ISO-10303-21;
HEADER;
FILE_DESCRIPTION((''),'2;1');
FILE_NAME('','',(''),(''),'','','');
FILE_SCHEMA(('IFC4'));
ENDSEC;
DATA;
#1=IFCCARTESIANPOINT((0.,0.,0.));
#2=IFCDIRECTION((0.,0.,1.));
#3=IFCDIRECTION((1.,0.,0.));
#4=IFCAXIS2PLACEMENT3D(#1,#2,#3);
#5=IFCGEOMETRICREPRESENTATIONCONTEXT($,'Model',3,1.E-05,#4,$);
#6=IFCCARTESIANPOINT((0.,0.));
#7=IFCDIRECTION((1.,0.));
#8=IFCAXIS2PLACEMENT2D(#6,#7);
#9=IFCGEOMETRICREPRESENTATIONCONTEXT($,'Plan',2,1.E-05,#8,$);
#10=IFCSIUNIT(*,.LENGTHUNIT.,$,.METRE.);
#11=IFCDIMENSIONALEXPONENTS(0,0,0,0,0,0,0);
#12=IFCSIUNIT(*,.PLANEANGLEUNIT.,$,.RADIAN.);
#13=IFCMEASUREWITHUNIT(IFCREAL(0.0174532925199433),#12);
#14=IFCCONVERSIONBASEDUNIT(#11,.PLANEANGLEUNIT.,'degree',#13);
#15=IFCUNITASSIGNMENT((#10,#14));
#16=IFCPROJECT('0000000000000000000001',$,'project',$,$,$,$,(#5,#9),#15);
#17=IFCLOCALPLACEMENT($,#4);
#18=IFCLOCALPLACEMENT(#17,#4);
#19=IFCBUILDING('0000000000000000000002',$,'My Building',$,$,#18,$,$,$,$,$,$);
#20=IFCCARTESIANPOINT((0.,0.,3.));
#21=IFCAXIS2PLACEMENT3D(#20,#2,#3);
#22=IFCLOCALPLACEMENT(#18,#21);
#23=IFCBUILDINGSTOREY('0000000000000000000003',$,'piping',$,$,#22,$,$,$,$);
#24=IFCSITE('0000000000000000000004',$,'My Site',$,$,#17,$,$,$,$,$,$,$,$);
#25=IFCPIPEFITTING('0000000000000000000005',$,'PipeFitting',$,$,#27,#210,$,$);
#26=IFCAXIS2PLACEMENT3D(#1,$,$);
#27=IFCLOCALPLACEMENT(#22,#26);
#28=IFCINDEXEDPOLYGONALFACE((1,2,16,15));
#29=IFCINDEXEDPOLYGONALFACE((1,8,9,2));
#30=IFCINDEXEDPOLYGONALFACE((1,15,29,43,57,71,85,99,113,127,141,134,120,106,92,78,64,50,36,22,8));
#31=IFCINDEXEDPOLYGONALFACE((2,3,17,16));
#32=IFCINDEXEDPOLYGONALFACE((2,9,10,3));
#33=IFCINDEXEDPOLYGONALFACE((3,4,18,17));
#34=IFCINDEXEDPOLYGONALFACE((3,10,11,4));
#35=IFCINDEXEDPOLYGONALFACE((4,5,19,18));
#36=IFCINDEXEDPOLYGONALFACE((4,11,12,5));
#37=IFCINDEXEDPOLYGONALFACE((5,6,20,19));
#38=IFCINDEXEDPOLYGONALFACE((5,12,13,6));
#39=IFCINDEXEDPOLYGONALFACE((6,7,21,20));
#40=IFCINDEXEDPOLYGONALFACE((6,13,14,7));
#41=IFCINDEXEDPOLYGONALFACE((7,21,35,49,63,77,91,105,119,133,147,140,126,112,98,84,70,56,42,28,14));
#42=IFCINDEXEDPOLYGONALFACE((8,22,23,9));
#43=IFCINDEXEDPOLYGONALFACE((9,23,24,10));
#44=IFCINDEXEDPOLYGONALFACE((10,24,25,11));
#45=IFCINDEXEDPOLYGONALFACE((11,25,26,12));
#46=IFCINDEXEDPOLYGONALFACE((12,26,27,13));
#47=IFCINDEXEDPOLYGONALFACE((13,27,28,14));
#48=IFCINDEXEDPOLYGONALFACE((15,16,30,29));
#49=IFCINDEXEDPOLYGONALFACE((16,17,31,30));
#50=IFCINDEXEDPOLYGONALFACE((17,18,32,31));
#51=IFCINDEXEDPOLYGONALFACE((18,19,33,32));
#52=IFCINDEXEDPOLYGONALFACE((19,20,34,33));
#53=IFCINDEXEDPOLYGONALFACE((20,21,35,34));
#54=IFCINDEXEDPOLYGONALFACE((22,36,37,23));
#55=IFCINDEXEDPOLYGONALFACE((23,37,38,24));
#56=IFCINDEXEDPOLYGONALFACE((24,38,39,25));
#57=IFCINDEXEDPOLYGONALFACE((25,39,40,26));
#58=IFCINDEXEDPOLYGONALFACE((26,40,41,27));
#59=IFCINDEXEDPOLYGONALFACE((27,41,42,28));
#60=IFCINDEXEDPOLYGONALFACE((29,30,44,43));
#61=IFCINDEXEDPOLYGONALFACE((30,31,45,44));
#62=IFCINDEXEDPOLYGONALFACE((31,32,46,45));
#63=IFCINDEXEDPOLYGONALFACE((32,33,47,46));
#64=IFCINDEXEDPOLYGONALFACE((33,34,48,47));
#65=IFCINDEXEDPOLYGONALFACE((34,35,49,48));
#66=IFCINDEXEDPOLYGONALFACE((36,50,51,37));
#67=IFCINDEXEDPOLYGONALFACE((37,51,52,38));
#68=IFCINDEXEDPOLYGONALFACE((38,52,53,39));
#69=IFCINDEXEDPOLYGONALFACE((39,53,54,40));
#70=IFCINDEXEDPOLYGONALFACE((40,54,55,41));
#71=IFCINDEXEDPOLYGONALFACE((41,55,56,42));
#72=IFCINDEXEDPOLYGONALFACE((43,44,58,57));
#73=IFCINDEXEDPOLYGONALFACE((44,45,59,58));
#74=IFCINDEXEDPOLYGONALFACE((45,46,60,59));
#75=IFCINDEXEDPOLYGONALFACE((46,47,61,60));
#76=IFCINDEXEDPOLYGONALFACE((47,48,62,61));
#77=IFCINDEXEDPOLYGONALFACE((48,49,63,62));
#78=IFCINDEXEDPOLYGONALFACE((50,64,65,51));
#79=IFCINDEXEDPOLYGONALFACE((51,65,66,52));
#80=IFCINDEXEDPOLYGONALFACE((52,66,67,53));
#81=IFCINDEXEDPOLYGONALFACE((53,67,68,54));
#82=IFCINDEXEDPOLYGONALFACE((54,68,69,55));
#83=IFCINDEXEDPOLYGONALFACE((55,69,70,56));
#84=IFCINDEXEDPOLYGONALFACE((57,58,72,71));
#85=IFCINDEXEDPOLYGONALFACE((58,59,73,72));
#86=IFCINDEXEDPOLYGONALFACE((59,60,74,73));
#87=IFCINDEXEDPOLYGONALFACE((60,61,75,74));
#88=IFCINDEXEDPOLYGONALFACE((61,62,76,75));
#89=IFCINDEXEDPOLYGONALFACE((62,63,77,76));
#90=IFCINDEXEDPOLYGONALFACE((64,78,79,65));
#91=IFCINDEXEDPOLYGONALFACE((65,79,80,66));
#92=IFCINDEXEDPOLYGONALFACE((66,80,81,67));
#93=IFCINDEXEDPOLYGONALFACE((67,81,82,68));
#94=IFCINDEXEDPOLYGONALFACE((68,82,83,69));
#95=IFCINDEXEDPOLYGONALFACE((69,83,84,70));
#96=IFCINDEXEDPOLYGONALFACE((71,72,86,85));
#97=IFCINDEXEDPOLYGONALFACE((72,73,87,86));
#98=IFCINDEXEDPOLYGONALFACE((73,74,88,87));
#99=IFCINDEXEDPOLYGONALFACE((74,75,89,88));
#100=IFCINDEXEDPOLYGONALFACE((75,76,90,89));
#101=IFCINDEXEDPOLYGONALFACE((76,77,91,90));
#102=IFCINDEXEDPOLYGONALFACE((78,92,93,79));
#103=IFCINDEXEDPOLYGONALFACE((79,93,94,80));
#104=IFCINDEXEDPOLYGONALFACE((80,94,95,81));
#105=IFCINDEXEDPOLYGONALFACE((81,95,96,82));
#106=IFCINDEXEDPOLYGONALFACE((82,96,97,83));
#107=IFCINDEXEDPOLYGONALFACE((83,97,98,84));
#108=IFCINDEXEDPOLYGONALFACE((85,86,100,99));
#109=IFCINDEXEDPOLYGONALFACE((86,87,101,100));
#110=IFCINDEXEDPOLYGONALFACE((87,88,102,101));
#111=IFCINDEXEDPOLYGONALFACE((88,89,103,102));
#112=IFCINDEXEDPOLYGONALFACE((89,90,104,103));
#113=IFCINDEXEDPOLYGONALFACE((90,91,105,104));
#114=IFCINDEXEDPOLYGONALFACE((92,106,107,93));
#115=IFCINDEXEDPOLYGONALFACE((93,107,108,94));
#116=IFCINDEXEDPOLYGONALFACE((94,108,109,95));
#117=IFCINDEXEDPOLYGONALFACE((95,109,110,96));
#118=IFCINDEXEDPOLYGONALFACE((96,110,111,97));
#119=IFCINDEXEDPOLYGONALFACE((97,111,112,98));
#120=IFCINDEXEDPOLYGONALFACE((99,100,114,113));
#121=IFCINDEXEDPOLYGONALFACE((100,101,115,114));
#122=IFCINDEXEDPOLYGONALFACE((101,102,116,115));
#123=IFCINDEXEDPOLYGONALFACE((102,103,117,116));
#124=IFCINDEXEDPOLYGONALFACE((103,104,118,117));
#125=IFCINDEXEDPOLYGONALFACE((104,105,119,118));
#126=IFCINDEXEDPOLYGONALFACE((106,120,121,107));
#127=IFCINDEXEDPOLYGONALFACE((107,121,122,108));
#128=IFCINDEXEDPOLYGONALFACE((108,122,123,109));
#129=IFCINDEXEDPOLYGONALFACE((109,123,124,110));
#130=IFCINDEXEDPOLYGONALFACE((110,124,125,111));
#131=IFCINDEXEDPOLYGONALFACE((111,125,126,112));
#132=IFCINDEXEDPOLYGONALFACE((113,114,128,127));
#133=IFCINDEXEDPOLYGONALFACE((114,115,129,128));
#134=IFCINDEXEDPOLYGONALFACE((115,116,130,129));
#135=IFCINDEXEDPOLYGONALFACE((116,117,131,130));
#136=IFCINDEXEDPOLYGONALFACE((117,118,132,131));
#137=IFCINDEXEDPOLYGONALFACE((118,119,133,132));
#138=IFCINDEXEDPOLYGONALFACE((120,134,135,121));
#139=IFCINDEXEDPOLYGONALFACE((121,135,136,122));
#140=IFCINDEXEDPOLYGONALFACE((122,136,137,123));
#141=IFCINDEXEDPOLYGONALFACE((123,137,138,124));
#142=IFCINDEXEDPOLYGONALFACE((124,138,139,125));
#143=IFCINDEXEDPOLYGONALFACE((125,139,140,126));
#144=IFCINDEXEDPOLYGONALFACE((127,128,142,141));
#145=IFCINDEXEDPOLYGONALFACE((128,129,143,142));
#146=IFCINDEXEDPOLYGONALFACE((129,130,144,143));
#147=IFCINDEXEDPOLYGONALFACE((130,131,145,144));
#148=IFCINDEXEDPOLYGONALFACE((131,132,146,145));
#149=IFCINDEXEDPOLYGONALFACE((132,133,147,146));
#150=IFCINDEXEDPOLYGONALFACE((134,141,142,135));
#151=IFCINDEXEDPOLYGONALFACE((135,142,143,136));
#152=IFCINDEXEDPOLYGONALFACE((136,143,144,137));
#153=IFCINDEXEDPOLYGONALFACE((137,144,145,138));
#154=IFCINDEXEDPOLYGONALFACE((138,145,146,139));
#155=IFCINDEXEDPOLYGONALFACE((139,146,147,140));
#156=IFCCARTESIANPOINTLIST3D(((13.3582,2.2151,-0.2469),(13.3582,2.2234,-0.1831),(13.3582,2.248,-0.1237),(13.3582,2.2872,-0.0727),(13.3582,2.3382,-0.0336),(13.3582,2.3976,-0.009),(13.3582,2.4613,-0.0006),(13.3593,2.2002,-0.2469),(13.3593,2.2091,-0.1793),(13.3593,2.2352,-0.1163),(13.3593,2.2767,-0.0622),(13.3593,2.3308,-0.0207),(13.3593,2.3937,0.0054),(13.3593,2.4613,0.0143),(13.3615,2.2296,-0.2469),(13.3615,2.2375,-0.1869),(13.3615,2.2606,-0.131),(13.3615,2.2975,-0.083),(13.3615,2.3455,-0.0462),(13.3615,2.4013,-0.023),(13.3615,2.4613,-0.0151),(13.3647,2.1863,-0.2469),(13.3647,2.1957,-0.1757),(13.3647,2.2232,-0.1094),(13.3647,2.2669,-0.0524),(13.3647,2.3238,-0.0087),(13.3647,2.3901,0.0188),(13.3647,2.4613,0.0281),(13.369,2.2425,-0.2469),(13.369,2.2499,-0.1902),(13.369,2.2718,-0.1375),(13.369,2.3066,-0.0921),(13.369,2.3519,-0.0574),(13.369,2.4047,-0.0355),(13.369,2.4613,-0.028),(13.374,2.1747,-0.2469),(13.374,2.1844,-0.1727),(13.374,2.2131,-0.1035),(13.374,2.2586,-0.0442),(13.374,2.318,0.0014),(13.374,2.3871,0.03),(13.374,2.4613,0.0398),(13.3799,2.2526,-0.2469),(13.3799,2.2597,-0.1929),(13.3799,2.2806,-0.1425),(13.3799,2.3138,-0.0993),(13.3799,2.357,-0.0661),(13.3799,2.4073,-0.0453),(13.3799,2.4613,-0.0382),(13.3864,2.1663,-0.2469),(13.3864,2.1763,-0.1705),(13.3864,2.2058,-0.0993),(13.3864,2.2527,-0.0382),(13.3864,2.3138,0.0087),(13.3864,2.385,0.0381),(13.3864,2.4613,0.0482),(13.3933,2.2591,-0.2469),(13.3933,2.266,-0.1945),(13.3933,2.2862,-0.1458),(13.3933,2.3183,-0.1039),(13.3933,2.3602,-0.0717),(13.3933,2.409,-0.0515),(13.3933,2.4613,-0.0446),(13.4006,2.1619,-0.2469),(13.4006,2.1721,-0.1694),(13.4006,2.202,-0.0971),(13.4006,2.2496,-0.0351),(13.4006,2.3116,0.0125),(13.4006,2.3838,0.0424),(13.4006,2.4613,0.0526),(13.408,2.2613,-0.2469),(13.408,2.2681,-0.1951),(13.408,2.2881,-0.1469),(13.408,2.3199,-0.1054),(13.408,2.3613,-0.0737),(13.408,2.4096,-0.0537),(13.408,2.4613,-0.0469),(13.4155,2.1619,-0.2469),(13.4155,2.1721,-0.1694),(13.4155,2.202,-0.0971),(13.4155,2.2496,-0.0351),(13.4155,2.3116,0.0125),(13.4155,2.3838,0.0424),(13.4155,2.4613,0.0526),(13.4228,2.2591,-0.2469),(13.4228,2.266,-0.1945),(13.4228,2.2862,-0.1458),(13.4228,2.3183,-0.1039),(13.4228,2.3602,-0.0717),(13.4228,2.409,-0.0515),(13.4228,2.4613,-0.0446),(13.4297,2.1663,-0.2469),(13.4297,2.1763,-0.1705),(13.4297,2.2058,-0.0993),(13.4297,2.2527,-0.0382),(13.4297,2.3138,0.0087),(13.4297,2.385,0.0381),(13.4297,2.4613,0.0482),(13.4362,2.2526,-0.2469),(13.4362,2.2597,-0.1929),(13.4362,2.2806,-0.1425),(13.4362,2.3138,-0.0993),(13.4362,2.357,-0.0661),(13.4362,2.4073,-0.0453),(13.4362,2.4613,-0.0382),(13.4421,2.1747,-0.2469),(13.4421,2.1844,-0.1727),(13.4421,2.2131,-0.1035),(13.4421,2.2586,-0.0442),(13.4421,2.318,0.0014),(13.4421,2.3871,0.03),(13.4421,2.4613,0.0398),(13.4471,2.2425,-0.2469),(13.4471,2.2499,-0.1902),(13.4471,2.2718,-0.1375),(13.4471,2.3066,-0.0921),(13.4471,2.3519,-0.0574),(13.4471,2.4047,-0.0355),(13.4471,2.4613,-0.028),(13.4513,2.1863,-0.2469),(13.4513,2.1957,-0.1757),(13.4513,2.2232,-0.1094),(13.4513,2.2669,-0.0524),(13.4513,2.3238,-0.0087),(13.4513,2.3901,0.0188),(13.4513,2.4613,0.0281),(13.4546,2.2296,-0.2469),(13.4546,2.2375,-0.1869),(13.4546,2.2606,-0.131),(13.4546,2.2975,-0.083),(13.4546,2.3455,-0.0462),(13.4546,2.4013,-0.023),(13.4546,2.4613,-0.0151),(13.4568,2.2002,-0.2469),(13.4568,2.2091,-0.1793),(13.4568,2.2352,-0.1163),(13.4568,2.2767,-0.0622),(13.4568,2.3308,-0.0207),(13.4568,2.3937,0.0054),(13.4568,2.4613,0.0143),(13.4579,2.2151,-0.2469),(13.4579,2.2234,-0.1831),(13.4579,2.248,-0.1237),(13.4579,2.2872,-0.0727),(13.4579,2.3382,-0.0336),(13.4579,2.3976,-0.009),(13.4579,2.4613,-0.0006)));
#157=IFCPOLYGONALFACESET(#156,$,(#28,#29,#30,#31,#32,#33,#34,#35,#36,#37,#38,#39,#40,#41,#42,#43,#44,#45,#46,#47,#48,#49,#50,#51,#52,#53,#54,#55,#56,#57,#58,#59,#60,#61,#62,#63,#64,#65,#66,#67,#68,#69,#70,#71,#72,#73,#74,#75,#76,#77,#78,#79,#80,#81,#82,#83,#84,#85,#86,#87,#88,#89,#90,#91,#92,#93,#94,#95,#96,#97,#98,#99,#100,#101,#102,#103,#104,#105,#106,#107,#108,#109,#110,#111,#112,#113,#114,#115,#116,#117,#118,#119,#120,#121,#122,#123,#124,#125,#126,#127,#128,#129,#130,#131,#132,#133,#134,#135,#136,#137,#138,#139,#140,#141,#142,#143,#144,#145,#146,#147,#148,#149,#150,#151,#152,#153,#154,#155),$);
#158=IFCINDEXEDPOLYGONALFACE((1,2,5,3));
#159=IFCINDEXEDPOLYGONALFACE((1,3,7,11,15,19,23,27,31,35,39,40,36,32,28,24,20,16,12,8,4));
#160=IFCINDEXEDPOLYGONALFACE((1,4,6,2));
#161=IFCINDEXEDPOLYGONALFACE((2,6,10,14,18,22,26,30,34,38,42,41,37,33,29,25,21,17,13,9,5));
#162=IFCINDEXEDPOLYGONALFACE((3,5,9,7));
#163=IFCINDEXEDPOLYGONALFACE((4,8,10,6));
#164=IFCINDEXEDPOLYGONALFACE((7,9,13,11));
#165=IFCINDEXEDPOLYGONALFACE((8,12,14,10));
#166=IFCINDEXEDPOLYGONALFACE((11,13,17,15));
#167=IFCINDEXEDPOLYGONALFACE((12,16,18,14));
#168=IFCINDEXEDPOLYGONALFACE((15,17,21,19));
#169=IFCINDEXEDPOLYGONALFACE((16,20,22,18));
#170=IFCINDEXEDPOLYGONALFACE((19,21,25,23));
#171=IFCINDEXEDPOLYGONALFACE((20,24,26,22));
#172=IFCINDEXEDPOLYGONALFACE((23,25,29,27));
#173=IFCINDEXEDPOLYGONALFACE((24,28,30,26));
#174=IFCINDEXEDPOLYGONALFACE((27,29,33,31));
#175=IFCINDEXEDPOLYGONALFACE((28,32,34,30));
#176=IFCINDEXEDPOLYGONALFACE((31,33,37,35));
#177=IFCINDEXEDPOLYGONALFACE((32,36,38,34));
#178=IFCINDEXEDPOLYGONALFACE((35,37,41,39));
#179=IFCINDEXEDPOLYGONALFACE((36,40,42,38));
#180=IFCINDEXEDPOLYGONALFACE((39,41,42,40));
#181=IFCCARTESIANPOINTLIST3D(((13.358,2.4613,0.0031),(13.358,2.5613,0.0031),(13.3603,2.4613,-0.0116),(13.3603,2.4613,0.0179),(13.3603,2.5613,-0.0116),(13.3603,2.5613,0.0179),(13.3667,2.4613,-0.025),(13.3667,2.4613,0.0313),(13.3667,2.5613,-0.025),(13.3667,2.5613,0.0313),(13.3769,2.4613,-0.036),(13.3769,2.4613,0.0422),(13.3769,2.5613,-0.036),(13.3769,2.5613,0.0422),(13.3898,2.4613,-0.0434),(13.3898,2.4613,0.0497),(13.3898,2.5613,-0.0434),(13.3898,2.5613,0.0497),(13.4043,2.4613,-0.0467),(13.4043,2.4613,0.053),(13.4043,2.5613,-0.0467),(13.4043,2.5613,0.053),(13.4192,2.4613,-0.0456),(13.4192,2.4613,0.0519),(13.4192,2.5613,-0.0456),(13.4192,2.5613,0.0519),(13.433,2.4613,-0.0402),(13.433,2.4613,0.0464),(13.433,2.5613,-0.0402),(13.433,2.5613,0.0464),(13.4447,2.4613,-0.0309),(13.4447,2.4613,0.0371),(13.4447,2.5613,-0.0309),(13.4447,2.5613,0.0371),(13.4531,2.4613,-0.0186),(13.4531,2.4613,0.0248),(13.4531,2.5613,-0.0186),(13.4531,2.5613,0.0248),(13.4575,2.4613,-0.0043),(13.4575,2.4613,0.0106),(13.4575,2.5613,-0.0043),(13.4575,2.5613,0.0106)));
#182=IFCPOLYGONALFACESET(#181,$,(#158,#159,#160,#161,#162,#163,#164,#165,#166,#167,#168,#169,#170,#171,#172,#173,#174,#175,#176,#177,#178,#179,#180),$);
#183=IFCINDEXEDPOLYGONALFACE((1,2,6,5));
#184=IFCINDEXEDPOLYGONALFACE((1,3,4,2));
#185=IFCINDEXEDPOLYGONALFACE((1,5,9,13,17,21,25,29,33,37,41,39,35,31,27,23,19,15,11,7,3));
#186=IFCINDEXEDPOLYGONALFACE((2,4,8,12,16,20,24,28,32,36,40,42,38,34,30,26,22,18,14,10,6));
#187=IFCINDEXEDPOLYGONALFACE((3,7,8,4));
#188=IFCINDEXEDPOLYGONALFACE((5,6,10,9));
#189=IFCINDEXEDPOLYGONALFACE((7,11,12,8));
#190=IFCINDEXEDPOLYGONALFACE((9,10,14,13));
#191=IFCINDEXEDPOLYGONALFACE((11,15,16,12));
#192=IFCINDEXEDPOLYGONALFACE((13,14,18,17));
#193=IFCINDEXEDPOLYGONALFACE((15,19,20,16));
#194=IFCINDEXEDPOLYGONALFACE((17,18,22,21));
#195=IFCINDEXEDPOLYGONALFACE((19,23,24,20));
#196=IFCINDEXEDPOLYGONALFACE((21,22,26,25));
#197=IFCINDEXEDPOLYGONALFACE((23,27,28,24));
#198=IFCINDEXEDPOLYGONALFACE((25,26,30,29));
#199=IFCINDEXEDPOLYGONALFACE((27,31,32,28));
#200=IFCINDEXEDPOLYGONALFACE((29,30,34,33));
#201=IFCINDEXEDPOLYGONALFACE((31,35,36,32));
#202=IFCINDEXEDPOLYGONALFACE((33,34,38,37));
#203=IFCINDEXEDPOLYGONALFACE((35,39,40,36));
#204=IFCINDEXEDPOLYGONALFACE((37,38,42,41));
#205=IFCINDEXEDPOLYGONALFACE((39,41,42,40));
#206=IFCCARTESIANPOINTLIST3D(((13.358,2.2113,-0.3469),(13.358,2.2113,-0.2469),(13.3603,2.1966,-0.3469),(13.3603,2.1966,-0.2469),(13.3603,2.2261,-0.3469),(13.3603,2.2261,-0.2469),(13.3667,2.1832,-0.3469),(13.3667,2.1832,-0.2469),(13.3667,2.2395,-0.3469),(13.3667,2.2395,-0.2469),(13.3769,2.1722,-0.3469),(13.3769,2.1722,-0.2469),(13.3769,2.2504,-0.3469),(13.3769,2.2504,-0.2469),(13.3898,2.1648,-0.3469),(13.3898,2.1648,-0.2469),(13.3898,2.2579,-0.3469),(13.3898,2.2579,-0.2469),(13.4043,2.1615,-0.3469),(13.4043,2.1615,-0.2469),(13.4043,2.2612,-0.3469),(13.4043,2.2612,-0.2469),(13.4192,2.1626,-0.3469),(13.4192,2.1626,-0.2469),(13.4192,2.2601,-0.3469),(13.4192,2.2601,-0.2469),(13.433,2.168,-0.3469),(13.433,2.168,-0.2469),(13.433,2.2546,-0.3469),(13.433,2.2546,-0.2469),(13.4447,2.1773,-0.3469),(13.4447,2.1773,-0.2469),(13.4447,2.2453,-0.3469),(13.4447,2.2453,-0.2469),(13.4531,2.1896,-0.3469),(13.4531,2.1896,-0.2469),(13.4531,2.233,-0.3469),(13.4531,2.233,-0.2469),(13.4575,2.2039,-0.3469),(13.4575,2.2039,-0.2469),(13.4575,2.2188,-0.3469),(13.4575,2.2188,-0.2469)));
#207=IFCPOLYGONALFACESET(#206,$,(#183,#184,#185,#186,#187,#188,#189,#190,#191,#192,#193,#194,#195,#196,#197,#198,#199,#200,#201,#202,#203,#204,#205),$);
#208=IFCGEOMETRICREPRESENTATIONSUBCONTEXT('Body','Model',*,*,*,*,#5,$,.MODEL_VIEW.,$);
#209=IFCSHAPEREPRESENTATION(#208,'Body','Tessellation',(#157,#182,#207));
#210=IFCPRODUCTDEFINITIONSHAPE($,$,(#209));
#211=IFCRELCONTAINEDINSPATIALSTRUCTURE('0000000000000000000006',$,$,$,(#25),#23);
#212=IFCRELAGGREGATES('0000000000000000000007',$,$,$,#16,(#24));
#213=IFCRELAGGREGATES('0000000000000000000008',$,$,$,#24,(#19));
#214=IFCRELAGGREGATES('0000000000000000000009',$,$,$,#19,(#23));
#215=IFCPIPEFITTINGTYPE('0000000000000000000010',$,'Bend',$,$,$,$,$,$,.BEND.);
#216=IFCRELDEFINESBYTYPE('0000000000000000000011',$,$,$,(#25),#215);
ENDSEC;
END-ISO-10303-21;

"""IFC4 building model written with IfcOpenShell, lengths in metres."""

from ifc_helpers import new_model, entity, si_unit, converted_unit, frame, origin_with_axes, origin_2d_with_axis, place, context, subcontext, project, spatial, circle, extrude, source, transform, mapped, type_object, type_shapes, element, save


model = new_model("IFC4")

# Units and contexts
model_context = context("Model", 3, precision=1e-05, world=origin_with_axes())
plan_context = context("Plan", 2, precision=1e-05, world=origin_2d_with_axis())
body_context = subcontext(model_context, "Body", "Model", "MODEL_VIEW")
ifc_project = project(units=[si_unit("LENGTHUNIT", "METRE"), converted_unit("PLANEANGLEUNIT", "degree", entity("IfcReal", 0.0174532925199433), si_unit("PLANEANGLEUNIT", "RADIAN"), dimensions=[0, 0, 0, 0, 0, 0, 0])], contexts=[model_context, plan_context])

# Site, building, storey
site_placement = place(None, origin_with_axes())
site = spatial("IfcSite", under=ifc_project, at=site_placement, Name="My Site")
building_placement = place(site_placement, origin_with_axes())
building = spatial("IfcBuilding", under=site, at=building_placement, Name="My Building")
storey_placement = place(building_placement, frame((0.0, 0.0, 3.0), z_axis=(0.0, 0.0, 1.0), x_axis=(1.0, 0.0, 0.0)))
storey = spatial("IfcBuildingStorey", under=building, at=storey_placement, Name="piping")

# Pipe fitting
pipe_fitting_type = type_object("IfcPipeFittingType", Name="Bend", PredefinedType="BEND")
shared_shape = source(origin_with_axes(), body_context, "Body", "SolidModel", [
    entity("IfcSweptDiskSolid", entity("IfcIndexedPolyCurve", entity("IfcCartesianPointList3D", [[0.0, 0.0, -0.1], [0.0, -0.0732, -0.2768], [0.0, -0.25, -0.35]]), [entity("IfcArcIndex", [1, 2, 3])]), 0.05),
    extrude(circle(Radius=0.05), origin_with_axes(), (0.0, 0.0, -1.0), 0.1),
    extrude(circle(Radius=0.05), frame((0.0, -0.25, -0.35), z_axis=(0.0, -1.0, 0.0), x_axis=(1.0, 0.0, 0.0)), (0.0, 0.0, 1.0), 0.1),
])
type_shapes(pipe_fitting_type, [shared_shape])
for number, where, z_axis, x_axis, name in (
    (1, (13.408, 2.5613, 0.0031), (0.0, 1.0, 0.0), (-1.0, 0.0, 0.0), "PipeFitting"),
):
    element("IfcPipeFitting", number, at=place(storey_placement, frame(where, z_axis=z_axis, x_axis=x_axis)), inside=storey, type_object=pipe_fitting_type, Name=name, context=body_context, shape_type="MappedRepresentation", body=[
        mapped(shared_shape, transform((0.0, 0.0, 0.0), x_axis=(1.0, 0.0, 0.0), y_axis=(0.0, 1.0, 0.0), z_axis=(0.0, 0.0, 1.0), scale=1.0)),
    ])

save(model, "model.ifc")
